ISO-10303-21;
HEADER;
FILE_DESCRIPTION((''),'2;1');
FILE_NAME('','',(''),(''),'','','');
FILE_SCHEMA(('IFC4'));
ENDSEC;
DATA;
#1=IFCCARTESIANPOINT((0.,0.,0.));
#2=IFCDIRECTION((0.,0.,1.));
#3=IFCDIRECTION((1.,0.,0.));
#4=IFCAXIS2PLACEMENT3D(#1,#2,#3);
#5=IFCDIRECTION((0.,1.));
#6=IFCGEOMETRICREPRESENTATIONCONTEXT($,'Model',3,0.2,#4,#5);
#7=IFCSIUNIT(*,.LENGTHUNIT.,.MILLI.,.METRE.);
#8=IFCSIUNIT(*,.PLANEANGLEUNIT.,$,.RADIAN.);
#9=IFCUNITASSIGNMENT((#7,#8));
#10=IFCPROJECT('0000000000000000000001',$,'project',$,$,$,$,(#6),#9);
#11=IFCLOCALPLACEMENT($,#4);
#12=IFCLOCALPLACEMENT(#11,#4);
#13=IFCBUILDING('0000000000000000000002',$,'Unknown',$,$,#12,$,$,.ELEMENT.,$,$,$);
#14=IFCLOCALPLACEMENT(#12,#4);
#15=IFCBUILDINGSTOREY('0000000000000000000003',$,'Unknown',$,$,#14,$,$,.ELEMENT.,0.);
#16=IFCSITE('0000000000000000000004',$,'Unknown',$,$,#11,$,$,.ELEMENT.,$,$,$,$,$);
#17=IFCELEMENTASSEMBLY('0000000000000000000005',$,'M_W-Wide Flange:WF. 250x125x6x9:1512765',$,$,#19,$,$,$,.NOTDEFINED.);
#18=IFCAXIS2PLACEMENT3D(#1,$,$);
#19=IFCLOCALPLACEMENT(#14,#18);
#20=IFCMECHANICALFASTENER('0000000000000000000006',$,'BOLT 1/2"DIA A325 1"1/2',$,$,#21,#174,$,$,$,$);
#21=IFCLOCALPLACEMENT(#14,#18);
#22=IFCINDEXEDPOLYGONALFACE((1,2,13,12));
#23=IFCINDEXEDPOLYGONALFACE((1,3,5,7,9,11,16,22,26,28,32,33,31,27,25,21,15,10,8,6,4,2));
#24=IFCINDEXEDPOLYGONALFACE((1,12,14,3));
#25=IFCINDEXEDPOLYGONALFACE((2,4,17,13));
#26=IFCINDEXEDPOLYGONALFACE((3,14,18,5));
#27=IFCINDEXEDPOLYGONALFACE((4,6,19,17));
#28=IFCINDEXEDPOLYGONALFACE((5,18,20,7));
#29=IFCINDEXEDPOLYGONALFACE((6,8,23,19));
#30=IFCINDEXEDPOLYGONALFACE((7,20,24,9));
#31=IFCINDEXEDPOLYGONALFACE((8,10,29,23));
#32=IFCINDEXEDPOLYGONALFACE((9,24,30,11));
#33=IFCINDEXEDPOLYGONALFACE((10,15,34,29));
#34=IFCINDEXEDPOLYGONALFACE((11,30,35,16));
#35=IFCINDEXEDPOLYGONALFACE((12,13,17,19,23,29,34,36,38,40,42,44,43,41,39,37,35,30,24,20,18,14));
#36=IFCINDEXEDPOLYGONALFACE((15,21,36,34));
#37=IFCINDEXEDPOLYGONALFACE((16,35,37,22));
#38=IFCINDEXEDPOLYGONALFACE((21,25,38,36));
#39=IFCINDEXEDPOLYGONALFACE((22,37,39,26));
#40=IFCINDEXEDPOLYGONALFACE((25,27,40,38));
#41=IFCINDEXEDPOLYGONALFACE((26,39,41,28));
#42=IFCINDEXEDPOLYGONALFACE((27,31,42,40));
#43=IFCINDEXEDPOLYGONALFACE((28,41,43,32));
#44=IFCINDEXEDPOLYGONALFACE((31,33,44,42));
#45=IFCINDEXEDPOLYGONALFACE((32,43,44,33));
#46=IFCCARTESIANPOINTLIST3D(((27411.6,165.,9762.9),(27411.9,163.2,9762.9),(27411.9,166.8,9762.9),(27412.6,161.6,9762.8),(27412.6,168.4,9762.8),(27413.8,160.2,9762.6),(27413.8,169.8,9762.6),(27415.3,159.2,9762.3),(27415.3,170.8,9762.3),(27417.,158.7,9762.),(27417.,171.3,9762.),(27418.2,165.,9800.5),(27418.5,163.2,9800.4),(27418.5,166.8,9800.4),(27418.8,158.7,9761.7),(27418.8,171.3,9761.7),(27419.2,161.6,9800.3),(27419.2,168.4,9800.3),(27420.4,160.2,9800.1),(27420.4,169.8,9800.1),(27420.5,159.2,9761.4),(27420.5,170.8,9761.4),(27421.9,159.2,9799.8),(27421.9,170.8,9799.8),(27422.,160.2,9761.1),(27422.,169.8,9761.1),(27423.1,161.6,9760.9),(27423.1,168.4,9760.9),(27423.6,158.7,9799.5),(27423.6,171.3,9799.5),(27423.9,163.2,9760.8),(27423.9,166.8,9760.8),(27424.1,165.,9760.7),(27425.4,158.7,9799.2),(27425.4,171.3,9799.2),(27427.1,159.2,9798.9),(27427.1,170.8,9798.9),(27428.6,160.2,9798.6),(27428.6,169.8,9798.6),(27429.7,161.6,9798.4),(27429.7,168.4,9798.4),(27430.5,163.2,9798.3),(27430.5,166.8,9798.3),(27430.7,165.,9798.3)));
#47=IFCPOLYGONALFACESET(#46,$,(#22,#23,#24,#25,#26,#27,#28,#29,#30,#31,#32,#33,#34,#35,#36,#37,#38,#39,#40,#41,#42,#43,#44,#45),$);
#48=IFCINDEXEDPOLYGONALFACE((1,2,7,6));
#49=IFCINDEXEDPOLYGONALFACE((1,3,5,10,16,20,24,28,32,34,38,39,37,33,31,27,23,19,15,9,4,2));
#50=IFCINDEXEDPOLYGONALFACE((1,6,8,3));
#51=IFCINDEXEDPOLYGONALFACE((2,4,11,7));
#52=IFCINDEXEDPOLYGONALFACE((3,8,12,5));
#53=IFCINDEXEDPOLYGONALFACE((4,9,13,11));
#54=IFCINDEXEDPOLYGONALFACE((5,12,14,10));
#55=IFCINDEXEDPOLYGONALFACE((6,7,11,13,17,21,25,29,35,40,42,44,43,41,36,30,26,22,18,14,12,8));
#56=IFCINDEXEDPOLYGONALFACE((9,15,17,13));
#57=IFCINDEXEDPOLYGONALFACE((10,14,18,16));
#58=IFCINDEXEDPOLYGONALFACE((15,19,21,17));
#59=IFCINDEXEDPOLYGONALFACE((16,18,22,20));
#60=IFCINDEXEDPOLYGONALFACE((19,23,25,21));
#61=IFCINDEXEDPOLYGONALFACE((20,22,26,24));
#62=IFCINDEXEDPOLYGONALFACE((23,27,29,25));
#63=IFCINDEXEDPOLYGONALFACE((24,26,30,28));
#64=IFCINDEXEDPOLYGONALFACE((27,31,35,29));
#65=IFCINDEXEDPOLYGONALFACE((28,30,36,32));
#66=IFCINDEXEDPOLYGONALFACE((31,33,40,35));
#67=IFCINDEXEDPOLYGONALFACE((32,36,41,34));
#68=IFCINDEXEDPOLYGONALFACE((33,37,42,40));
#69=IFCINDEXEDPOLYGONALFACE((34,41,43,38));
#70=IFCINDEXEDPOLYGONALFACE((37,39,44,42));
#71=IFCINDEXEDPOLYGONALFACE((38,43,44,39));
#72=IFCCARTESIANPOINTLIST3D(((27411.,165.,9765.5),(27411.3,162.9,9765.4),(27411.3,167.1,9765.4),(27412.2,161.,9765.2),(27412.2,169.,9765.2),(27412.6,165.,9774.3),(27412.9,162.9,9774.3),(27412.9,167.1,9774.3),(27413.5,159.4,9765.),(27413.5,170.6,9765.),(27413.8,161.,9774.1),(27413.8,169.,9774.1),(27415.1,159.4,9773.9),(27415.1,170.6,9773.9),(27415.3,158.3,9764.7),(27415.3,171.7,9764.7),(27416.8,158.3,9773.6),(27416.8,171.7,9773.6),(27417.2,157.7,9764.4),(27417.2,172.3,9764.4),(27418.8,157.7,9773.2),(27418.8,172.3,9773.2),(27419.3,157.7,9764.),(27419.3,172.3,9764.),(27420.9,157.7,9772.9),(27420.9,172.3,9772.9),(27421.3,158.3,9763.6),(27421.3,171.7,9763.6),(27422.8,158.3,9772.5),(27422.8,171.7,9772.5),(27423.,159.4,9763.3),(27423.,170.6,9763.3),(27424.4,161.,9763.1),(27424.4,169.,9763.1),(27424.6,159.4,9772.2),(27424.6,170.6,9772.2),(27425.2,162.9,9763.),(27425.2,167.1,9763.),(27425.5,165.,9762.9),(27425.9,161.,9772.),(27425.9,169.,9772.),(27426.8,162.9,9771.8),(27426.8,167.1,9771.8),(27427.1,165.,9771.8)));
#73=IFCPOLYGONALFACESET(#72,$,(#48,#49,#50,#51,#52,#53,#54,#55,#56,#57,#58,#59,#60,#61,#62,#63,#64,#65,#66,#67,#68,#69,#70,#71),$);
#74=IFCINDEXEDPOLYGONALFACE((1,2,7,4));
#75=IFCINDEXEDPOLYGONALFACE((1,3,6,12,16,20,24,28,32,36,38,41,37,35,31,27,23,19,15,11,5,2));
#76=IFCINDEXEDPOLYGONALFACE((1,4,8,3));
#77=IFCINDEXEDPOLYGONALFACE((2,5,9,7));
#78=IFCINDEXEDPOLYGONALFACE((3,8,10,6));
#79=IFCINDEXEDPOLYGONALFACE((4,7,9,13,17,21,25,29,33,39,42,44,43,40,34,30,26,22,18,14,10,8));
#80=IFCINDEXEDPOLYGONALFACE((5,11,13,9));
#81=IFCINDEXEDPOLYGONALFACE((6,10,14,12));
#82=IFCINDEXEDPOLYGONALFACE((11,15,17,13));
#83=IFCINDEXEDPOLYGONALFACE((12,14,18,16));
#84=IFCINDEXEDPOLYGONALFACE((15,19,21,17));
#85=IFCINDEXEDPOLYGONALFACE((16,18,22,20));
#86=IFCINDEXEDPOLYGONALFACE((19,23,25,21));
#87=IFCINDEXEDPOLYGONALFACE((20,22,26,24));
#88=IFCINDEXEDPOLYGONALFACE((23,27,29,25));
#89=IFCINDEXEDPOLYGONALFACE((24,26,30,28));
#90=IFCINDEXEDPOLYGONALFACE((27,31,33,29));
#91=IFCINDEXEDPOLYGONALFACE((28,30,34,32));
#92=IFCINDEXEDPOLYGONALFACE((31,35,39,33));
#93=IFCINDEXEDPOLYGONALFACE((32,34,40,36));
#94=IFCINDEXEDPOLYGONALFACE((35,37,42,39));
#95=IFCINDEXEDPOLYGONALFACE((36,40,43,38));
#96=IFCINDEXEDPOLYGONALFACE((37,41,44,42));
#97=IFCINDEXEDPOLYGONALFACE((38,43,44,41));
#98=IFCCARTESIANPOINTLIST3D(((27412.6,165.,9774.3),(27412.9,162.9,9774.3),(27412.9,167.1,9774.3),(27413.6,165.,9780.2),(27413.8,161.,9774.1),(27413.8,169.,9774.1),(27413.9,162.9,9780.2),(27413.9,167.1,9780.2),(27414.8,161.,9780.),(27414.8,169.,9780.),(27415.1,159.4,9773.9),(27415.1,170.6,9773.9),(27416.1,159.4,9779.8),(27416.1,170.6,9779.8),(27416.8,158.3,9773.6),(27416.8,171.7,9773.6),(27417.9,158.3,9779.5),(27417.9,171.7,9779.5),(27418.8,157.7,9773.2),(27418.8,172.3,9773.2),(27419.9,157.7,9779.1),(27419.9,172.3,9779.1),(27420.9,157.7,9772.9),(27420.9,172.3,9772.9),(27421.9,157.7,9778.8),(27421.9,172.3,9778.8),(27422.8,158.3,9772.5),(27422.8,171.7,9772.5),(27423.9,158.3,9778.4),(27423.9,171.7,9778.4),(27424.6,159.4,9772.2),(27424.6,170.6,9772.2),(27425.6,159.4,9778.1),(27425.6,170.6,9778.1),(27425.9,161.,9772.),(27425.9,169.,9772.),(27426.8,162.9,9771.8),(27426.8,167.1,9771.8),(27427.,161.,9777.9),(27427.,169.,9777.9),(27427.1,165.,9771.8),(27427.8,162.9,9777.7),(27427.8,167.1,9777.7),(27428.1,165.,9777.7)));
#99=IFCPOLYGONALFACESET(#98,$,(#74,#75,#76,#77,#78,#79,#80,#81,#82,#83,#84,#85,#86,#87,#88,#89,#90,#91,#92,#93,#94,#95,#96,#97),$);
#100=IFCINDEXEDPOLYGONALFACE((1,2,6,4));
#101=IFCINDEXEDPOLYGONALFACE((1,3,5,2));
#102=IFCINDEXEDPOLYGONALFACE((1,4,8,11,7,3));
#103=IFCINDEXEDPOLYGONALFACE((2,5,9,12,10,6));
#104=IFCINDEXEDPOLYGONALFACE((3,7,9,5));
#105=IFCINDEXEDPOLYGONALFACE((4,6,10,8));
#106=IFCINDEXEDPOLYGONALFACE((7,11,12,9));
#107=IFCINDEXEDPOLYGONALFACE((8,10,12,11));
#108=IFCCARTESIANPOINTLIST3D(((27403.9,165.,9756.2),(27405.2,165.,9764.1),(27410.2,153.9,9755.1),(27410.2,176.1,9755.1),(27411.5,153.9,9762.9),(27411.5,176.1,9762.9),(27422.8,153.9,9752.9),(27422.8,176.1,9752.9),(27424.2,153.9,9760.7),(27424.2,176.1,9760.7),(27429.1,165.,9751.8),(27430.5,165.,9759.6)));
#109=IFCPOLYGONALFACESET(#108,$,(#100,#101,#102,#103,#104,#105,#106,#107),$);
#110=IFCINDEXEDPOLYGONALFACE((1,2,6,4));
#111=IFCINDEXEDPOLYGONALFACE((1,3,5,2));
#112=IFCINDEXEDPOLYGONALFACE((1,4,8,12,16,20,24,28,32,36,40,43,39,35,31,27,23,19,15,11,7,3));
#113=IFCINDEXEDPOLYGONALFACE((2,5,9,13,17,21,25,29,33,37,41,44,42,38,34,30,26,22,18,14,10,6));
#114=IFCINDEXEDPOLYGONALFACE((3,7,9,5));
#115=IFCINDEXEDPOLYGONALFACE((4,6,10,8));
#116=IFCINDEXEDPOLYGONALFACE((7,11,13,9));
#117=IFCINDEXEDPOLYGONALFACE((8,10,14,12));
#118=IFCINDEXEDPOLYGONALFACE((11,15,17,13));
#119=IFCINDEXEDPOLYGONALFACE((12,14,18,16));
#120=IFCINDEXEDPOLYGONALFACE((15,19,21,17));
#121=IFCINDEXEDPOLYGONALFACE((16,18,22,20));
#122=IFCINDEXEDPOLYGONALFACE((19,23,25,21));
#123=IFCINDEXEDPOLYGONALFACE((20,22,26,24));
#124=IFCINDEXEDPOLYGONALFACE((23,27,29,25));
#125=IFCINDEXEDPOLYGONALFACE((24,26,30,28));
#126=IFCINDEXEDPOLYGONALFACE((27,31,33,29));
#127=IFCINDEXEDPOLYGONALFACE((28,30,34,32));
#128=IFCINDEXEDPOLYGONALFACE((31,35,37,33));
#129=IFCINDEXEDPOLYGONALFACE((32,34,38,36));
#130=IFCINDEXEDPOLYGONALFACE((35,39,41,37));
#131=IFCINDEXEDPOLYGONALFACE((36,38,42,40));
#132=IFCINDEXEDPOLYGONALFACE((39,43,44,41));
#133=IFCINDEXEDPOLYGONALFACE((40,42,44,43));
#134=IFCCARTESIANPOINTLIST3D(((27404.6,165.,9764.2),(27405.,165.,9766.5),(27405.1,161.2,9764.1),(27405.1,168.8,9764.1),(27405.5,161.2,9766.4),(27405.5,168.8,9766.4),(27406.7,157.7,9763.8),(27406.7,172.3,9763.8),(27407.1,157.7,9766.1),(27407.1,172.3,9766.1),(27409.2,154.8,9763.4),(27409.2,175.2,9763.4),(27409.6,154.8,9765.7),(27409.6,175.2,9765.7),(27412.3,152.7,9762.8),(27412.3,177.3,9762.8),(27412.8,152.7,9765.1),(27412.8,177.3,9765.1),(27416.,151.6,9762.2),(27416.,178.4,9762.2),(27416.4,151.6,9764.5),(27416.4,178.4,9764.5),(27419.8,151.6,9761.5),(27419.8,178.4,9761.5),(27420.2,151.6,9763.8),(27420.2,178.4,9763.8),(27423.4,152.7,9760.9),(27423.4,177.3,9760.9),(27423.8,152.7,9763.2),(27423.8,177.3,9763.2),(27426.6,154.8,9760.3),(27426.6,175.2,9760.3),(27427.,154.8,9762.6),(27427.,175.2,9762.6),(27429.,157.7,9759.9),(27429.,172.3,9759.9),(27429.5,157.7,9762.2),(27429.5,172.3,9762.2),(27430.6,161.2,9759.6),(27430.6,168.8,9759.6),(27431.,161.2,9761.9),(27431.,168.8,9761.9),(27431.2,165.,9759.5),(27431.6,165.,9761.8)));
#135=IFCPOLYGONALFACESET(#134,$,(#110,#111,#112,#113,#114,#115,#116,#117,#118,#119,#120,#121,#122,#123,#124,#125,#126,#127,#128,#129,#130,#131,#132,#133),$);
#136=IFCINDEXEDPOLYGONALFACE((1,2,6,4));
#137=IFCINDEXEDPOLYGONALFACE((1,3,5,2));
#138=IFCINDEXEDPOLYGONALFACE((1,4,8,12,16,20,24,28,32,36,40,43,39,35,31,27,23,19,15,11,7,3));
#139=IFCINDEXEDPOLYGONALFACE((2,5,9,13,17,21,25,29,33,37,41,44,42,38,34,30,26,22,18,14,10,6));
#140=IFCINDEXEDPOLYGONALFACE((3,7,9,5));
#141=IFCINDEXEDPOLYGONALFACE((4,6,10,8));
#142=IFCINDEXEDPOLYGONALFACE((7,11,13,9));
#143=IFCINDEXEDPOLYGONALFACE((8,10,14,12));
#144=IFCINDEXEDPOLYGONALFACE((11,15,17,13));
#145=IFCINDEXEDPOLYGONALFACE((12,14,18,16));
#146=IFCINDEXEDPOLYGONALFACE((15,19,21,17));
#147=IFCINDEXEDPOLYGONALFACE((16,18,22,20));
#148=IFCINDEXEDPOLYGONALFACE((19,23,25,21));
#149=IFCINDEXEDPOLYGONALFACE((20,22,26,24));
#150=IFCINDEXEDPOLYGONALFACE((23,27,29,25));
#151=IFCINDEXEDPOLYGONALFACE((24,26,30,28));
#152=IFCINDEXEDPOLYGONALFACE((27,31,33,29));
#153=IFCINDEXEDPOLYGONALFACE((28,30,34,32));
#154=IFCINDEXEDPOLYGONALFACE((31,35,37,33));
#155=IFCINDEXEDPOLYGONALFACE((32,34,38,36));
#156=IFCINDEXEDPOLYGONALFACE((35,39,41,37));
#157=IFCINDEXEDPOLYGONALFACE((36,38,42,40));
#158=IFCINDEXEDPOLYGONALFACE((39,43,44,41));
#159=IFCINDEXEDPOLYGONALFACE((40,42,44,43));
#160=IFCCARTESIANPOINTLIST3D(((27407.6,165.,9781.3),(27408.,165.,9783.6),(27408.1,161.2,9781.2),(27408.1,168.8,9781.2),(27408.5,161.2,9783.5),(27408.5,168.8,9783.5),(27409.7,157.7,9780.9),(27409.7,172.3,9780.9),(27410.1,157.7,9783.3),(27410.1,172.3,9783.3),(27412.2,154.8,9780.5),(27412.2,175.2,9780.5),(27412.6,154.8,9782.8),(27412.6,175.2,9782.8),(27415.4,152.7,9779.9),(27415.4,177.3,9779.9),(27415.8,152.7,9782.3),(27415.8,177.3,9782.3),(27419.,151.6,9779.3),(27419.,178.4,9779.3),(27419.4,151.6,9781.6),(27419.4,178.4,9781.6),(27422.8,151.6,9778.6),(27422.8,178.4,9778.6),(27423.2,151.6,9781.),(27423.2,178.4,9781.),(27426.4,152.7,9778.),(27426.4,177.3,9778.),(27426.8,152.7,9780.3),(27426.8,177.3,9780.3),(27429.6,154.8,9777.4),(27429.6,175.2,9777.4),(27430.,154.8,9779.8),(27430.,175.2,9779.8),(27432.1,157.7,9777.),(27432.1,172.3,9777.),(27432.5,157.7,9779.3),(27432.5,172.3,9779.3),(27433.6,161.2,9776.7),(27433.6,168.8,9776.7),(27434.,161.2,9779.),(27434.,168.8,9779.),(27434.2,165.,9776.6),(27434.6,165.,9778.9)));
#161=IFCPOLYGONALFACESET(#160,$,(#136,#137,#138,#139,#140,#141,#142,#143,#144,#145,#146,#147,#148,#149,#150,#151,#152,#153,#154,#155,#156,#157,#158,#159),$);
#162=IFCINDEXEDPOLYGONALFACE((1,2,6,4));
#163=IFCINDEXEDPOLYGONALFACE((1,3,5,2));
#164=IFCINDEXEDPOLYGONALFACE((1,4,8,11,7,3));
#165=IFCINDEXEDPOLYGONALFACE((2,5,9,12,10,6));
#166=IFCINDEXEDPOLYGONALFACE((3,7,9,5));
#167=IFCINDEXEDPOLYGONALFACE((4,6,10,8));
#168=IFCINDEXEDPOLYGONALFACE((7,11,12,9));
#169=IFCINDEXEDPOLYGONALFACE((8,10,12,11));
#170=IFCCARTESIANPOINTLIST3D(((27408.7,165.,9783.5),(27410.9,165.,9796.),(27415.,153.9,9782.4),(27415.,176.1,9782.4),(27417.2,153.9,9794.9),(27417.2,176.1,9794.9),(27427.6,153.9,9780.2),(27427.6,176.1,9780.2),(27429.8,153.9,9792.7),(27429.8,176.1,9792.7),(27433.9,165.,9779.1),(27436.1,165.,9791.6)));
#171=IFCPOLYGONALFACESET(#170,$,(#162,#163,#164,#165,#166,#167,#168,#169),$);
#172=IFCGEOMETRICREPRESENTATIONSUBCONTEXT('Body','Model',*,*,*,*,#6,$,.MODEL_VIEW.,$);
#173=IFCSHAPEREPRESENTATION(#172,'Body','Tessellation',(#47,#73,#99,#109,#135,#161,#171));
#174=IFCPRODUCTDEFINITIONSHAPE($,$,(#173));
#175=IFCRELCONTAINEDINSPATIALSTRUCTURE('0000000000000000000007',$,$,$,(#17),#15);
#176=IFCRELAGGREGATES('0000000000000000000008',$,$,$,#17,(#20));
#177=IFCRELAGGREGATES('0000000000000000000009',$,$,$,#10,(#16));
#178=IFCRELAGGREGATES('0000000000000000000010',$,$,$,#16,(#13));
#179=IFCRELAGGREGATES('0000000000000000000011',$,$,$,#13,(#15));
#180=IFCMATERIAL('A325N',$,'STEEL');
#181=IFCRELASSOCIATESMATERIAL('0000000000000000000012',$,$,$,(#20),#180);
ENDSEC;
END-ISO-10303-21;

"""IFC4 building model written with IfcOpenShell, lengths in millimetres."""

from ifc_helpers import new_model, si_unit, direction, frame, origin_with_axes, place, context, subcontext, project, spatial, line, arc, indexed_curve, outline, extrude, source, transform, mapped, material, element, aggregate, save


model = new_model("IFC4")

# Units and contexts
model_context = context("Model", 3, precision=0.2, world=origin_with_axes(), true_north=direction((0.0, 1.0)))
body_context = subcontext(model_context, "Body", "Model", "MODEL_VIEW")
ifc_project = project(units=[si_unit("LENGTHUNIT", "METRE", prefix="MILLI"), si_unit("PLANEANGLEUNIT", "RADIAN")], contexts=[model_context])

# Site, building, storey
site_placement = place(None, origin_with_axes())
site = spatial("IfcSite", under=ifc_project, at=site_placement, Name="Unknown", CompositionType="ELEMENT")
building_placement = place(site_placement, origin_with_axes())
building = spatial("IfcBuilding", under=site, at=building_placement, Name="Unknown", CompositionType="ELEMENT")
storey_placement = place(building_placement, origin_with_axes())
storey = spatial("IfcBuildingStorey", under=building, at=storey_placement, Name="Unknown", CompositionType="ELEMENT", Elevation=0.0)

# Element assembly, mechanical fastener
assembly_1_placement = place(storey_placement, frame((27430.1, 0.0, 9644.3), z_axis=(0.984808, 0.0, -0.173648), x_axis=(0.0, 1.0, 0.0)))
assembly_1 = element("IfcElementAssembly", 1, at=assembly_1_placement, inside=storey, Name="M_W-Wide Flange:WF. 250x125x6x9:1512765", PredefinedType="NOTDEFINED")
ifc_material_1 = material(Name="A325N", Category="STEEL")
shared_shape = source(origin_with_axes(), body_context, "Body", "SweptSolid", [
    extrude(outline(indexed_curve([(6.3, 0.0), (0.0, 6.3), (-6.3, 0.0), (0.0, -6.3)], segments=[arc(1, 2, 3), arc(3, 4, 1)])), frame((0.0, 0.0, 17.4), z_axis=(0.0, 0.0, -1.0), x_axis=(0.0, 1.0, 0.0)), (0.0, 0.0, 1.0), 38.1),
    extrude(outline(indexed_curve([(7.3, 0.0), (0.0, 7.3), (-7.3, 0.0), (0.0, -7.3)], segments=[arc(1, 2, 3), arc(3, 4, 1)])), frame((0.0, 0.0, 15.0), z_axis=(0.0, 0.0, -1.0), x_axis=(0.0, 1.0, 0.0)), (0.0, 0.0, 1.0), 9.0),
    extrude(outline(indexed_curve([(7.3, 0.0), (0.0, 7.3), (-7.3, 0.0), (0.0, -7.3)], segments=[arc(1, 2, 3), arc(3, 4, 1)])), frame((0.0, 0.0, 6.0), z_axis=(0.0, 0.0, -1.0), x_axis=(0.0, 1.0, 0.0)), (0.0, 0.0, 1.0), 6.0),
    extrude(outline(indexed_curve([(12.8, 0.0), (6.4, 11.1), (-6.4, 11.1), (-12.8, 0.0), (-6.4, -11.1), (6.4, -11.1)], segments=[line(1, 2, 3, 4, 5, 6, 1)])), frame((0.0, 0.0, 25.3), z_axis=(0.0, 0.0, -1.0), x_axis=(0.0, 1.0, 0.0)), (0.0, 0.0, 1.0), 7.9),
    extrude(outline(indexed_curve([(13.5, 0.0), (0.0, 13.5), (-13.5, 0.0), (0.0, -13.5)], segments=[arc(1, 2, 3), arc(3, 4, 1)])), frame((0.0, 0.0, 17.4), z_axis=(0.0, 0.0, -1.0), x_axis=(0.0, 1.0, 0.0)), (0.0, 0.0, 1.0), 2.4),
    extrude(outline(indexed_curve([(13.5, 0.0), (0.0, 13.5), (-13.5, 0.0), (0.0, -13.5)], segments=[arc(1, 2, 3), arc(3, 4, 1)])), frame((0.0, 0.0, 0.0), z_axis=(0.0, 0.0, -1.0), x_axis=(0.0, 1.0, 0.0)), (0.0, 0.0, 1.0), 2.4),
    extrude(outline(indexed_curve([(12.8, 0.0), (6.4, 11.1), (-6.4, 11.1), (-12.8, 0.0), (-6.4, -11.1), (6.4, -11.1)], segments=[line(1, 2, 3, 4, 5, 6, 1)])), frame((0.0, 0.0, -2.4), z_axis=(0.0, 0.0, -1.0), x_axis=(0.0, 1.0, 0.0)), (0.0, 0.0, 1.0), 12.7),
])
mechanical_fastener_1_placement = place(assembly_1_placement, frame((165.0, 131.0, -32.5), z_axis=(0.0, -1.0, 0.0), x_axis=(1.0, 0.0, 0.0)))
mechanical_fastener_1 = element("IfcMechanicalFastener", 2, at=mechanical_fastener_1_placement, material=ifc_material_1, Name="BOLT 1/2\"DIA A325 1\"1/2", context=body_context, shape_type="MappedRepresentation", body=[
    mapped(shared_shape, transform((0.0, 0.0, 0.0))),
])
aggregate(assembly_1, [mechanical_fastener_1])

save(model, "model.ifc")
